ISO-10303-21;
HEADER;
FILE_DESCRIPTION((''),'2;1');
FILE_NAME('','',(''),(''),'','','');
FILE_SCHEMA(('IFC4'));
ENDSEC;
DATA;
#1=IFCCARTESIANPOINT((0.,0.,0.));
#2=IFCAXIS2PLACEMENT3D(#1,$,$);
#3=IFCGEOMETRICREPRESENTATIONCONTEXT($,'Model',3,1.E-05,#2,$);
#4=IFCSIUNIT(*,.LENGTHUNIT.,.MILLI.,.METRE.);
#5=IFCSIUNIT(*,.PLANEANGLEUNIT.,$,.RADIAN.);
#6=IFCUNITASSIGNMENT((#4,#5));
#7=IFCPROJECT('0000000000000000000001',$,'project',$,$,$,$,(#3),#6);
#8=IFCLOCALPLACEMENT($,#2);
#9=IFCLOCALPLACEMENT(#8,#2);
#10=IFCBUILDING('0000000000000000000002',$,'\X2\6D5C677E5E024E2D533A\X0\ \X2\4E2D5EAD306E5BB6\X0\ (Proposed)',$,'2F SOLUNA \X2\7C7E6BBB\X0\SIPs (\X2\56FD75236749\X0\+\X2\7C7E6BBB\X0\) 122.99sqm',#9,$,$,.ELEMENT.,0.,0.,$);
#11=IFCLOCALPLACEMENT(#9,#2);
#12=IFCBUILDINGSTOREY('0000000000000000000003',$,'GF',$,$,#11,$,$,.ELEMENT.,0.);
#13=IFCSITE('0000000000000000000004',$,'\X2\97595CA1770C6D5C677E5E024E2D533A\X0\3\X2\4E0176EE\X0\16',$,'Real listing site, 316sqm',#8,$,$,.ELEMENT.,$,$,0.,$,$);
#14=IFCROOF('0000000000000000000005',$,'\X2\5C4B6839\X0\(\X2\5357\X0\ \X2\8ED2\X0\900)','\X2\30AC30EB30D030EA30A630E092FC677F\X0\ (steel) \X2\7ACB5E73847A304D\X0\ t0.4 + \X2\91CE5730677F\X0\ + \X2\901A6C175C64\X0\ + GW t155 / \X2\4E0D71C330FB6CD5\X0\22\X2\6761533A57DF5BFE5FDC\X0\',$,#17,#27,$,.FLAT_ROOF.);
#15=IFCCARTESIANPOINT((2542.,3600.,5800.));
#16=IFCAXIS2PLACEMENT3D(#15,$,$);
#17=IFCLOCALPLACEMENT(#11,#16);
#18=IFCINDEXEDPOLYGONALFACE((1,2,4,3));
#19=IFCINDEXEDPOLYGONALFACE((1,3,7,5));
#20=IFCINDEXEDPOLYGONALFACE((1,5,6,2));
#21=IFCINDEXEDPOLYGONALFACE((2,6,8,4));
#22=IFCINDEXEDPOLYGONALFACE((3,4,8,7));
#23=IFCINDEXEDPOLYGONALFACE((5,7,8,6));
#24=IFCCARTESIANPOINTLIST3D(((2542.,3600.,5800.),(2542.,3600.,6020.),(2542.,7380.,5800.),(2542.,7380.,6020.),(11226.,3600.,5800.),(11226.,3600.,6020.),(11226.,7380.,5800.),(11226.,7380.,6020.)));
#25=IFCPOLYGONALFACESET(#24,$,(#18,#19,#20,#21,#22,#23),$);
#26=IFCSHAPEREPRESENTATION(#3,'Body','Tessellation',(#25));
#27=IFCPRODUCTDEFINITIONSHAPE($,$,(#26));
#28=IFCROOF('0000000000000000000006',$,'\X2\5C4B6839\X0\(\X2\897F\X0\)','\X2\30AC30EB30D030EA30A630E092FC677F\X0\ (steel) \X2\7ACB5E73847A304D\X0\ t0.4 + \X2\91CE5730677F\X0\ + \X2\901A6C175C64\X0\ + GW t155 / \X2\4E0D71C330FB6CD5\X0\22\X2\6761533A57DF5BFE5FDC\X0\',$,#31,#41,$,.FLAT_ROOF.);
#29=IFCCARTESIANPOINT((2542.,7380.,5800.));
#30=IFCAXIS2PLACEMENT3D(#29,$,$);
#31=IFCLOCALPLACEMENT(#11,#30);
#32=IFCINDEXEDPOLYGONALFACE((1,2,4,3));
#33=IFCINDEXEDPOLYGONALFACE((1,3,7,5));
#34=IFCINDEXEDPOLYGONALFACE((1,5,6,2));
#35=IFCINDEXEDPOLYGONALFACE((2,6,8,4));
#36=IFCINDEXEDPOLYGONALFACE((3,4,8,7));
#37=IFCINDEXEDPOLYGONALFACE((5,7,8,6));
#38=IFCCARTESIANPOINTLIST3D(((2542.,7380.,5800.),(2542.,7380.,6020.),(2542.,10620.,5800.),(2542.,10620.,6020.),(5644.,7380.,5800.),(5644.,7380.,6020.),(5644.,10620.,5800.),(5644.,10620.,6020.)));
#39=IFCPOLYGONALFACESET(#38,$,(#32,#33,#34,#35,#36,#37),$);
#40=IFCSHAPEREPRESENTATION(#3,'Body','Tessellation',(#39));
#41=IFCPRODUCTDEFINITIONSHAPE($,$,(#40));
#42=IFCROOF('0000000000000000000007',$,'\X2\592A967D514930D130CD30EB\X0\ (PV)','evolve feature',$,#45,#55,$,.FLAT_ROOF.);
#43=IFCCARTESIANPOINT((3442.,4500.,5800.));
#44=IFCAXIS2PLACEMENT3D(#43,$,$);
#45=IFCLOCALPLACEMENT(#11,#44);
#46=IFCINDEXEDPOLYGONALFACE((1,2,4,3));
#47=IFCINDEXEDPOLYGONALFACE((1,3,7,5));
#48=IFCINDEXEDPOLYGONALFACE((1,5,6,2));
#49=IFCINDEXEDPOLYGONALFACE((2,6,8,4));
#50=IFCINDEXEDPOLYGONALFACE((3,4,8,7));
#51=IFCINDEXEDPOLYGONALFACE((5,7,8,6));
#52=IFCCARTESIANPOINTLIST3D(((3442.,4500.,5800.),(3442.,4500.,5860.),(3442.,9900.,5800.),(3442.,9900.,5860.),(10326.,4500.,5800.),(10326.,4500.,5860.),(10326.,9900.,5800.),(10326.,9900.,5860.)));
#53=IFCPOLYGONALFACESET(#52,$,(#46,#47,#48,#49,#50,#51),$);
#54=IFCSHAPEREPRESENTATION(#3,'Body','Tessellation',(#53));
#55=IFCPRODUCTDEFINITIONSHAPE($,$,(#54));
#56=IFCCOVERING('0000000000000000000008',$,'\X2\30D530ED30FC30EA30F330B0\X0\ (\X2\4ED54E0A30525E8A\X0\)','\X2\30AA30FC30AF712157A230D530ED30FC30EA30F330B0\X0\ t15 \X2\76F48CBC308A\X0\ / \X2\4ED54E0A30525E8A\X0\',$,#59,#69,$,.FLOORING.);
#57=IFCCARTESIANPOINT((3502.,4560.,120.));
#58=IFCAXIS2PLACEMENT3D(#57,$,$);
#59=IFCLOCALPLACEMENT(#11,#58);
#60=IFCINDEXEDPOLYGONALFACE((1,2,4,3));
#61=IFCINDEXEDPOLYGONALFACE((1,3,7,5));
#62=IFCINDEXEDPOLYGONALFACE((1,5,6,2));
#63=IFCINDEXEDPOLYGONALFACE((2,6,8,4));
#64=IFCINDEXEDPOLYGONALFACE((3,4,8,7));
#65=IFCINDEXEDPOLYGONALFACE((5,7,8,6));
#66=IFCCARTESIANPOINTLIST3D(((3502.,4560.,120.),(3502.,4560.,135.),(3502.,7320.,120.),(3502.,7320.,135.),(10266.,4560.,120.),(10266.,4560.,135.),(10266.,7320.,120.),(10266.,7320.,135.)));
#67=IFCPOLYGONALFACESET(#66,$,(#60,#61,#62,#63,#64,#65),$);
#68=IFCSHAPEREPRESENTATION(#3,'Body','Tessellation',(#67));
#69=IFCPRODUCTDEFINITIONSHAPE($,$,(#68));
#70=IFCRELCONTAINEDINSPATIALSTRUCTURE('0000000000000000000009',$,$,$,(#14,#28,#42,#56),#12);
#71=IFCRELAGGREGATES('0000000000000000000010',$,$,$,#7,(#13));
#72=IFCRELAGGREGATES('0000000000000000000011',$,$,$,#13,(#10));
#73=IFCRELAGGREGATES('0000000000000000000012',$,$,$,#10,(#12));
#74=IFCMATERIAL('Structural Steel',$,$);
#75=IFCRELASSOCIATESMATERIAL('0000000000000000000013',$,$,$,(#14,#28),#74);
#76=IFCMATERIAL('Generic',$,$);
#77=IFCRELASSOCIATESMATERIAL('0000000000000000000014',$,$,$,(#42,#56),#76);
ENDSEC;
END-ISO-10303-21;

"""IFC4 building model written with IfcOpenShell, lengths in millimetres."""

from ifc_helpers import new_model, si_unit, frame, frame_2d, origin, place, context, project, spatial, rectangle, extrude, material, element, save


model = new_model("IFC4")

# Units and contexts
model_context = context("Model", 3, precision=1e-05, world=origin())
ifc_project = project(units=[si_unit("LENGTHUNIT", "METRE", prefix="MILLI"), si_unit("PLANEANGLEUNIT", "RADIAN")], contexts=[model_context])

# Site, building, storey
site_placement = place(None, origin())
site = spatial("IfcSite", under=ifc_project, at=site_placement, Name="静岡県浜松市中区3丁目16", ObjectType="Real listing site, 316sqm", CompositionType="ELEMENT", RefElevation=0.0)
building_placement = place(site_placement, origin())
building = spatial("IfcBuilding", under=site, at=building_placement, Name="浜松市中区 中庭の家 (Proposed)", ObjectType="2F SOLUNA 籾殻SIPs (国産杉+籾殻) 122.99sqm", CompositionType="ELEMENT", ElevationOfRefHeight=0.0, ElevationOfTerrain=0.0)
storey_placement = place(building_placement, origin())
storey = spatial("IfcBuildingStorey", under=building, at=storey_placement, Name="GF", CompositionType="ELEMENT", Elevation=0.0)

# Shared definitions
ifc_material_1 = material(Name="Generic")

# Roofs
ifc_material_2 = material(Name="Structural Steel")
roof_1_placement = place(storey_placement, frame((2542.0, 3600.0, 5800.0)))
element("IfcRoof", 1, at=roof_1_placement, inside=storey, material=ifc_material_2, Name="屋根(南 軒900)", Description="ガルバリウム鋼板 (steel) 立平葺き t0.4 + 野地板 + 通気層 + GW t155 / 不燃・法22条区域対応", PredefinedType="FLAT_ROOF", context=model_context, shape_type="SweptSolid", body=[
    extrude(rectangle(XDim=8684.0, YDim=3780.0, at=frame_2d((4342.0, 1890.0))), frame((2542.0, 3600.0, 5800.0)), (0.0, 0.0, 1.0), 220.0),
])
roof_2_placement = place(storey_placement, frame((2542.0, 7380.0, 5800.0)))
element("IfcRoof", 2, at=roof_2_placement, inside=storey, material=ifc_material_2, Name="屋根(西)", Description="ガルバリウム鋼板 (steel) 立平葺き t0.4 + 野地板 + 通気層 + GW t155 / 不燃・法22条区域対応", PredefinedType="FLAT_ROOF", context=model_context, shape_type="SweptSolid", body=[
    extrude(rectangle(XDim=3102.0, YDim=3240.0, at=frame_2d((1551.0, 1620.0))), frame((2542.0, 7380.0, 5800.0)), (0.0, 0.0, 1.0), 220.0),
])
roof_3_placement = place(storey_placement, frame((3442.0, 4500.0, 5800.0)))
element("IfcRoof", 3, at=roof_3_placement, inside=storey, material=ifc_material_1, Name="太陽光パネル (PV)", Description="evolve feature", PredefinedType="FLAT_ROOF", context=model_context, shape_type="SweptSolid", body=[
    extrude(rectangle(XDim=6884.0, YDim=5400.0, at=frame_2d((3442.0, 2700.0))), frame((3442.0, 4500.0, 5800.0)), (0.0, 0.0, 1.0), 60.0),
])

# Covering
covering_placement = place(storey_placement, frame((3502.0, 4560.0, 120.0)))
element("IfcCovering", 4, at=covering_placement, inside=storey, material=ifc_material_1, Name="フローリング (仕上げ床)", Description="オーク無垢フローリング t15 直貼り / 仕上げ床", PredefinedType="FLOORING", context=model_context, shape_type="SweptSolid", body=[
    extrude(rectangle(XDim=6764.0, YDim=2760.0, at=frame_2d((3382.0, 1380.0))), frame((3502.0, 4560.0, 120.0)), (0.0, 0.0, 1.0), 15.0),
])

save(model, "model.ifc")
